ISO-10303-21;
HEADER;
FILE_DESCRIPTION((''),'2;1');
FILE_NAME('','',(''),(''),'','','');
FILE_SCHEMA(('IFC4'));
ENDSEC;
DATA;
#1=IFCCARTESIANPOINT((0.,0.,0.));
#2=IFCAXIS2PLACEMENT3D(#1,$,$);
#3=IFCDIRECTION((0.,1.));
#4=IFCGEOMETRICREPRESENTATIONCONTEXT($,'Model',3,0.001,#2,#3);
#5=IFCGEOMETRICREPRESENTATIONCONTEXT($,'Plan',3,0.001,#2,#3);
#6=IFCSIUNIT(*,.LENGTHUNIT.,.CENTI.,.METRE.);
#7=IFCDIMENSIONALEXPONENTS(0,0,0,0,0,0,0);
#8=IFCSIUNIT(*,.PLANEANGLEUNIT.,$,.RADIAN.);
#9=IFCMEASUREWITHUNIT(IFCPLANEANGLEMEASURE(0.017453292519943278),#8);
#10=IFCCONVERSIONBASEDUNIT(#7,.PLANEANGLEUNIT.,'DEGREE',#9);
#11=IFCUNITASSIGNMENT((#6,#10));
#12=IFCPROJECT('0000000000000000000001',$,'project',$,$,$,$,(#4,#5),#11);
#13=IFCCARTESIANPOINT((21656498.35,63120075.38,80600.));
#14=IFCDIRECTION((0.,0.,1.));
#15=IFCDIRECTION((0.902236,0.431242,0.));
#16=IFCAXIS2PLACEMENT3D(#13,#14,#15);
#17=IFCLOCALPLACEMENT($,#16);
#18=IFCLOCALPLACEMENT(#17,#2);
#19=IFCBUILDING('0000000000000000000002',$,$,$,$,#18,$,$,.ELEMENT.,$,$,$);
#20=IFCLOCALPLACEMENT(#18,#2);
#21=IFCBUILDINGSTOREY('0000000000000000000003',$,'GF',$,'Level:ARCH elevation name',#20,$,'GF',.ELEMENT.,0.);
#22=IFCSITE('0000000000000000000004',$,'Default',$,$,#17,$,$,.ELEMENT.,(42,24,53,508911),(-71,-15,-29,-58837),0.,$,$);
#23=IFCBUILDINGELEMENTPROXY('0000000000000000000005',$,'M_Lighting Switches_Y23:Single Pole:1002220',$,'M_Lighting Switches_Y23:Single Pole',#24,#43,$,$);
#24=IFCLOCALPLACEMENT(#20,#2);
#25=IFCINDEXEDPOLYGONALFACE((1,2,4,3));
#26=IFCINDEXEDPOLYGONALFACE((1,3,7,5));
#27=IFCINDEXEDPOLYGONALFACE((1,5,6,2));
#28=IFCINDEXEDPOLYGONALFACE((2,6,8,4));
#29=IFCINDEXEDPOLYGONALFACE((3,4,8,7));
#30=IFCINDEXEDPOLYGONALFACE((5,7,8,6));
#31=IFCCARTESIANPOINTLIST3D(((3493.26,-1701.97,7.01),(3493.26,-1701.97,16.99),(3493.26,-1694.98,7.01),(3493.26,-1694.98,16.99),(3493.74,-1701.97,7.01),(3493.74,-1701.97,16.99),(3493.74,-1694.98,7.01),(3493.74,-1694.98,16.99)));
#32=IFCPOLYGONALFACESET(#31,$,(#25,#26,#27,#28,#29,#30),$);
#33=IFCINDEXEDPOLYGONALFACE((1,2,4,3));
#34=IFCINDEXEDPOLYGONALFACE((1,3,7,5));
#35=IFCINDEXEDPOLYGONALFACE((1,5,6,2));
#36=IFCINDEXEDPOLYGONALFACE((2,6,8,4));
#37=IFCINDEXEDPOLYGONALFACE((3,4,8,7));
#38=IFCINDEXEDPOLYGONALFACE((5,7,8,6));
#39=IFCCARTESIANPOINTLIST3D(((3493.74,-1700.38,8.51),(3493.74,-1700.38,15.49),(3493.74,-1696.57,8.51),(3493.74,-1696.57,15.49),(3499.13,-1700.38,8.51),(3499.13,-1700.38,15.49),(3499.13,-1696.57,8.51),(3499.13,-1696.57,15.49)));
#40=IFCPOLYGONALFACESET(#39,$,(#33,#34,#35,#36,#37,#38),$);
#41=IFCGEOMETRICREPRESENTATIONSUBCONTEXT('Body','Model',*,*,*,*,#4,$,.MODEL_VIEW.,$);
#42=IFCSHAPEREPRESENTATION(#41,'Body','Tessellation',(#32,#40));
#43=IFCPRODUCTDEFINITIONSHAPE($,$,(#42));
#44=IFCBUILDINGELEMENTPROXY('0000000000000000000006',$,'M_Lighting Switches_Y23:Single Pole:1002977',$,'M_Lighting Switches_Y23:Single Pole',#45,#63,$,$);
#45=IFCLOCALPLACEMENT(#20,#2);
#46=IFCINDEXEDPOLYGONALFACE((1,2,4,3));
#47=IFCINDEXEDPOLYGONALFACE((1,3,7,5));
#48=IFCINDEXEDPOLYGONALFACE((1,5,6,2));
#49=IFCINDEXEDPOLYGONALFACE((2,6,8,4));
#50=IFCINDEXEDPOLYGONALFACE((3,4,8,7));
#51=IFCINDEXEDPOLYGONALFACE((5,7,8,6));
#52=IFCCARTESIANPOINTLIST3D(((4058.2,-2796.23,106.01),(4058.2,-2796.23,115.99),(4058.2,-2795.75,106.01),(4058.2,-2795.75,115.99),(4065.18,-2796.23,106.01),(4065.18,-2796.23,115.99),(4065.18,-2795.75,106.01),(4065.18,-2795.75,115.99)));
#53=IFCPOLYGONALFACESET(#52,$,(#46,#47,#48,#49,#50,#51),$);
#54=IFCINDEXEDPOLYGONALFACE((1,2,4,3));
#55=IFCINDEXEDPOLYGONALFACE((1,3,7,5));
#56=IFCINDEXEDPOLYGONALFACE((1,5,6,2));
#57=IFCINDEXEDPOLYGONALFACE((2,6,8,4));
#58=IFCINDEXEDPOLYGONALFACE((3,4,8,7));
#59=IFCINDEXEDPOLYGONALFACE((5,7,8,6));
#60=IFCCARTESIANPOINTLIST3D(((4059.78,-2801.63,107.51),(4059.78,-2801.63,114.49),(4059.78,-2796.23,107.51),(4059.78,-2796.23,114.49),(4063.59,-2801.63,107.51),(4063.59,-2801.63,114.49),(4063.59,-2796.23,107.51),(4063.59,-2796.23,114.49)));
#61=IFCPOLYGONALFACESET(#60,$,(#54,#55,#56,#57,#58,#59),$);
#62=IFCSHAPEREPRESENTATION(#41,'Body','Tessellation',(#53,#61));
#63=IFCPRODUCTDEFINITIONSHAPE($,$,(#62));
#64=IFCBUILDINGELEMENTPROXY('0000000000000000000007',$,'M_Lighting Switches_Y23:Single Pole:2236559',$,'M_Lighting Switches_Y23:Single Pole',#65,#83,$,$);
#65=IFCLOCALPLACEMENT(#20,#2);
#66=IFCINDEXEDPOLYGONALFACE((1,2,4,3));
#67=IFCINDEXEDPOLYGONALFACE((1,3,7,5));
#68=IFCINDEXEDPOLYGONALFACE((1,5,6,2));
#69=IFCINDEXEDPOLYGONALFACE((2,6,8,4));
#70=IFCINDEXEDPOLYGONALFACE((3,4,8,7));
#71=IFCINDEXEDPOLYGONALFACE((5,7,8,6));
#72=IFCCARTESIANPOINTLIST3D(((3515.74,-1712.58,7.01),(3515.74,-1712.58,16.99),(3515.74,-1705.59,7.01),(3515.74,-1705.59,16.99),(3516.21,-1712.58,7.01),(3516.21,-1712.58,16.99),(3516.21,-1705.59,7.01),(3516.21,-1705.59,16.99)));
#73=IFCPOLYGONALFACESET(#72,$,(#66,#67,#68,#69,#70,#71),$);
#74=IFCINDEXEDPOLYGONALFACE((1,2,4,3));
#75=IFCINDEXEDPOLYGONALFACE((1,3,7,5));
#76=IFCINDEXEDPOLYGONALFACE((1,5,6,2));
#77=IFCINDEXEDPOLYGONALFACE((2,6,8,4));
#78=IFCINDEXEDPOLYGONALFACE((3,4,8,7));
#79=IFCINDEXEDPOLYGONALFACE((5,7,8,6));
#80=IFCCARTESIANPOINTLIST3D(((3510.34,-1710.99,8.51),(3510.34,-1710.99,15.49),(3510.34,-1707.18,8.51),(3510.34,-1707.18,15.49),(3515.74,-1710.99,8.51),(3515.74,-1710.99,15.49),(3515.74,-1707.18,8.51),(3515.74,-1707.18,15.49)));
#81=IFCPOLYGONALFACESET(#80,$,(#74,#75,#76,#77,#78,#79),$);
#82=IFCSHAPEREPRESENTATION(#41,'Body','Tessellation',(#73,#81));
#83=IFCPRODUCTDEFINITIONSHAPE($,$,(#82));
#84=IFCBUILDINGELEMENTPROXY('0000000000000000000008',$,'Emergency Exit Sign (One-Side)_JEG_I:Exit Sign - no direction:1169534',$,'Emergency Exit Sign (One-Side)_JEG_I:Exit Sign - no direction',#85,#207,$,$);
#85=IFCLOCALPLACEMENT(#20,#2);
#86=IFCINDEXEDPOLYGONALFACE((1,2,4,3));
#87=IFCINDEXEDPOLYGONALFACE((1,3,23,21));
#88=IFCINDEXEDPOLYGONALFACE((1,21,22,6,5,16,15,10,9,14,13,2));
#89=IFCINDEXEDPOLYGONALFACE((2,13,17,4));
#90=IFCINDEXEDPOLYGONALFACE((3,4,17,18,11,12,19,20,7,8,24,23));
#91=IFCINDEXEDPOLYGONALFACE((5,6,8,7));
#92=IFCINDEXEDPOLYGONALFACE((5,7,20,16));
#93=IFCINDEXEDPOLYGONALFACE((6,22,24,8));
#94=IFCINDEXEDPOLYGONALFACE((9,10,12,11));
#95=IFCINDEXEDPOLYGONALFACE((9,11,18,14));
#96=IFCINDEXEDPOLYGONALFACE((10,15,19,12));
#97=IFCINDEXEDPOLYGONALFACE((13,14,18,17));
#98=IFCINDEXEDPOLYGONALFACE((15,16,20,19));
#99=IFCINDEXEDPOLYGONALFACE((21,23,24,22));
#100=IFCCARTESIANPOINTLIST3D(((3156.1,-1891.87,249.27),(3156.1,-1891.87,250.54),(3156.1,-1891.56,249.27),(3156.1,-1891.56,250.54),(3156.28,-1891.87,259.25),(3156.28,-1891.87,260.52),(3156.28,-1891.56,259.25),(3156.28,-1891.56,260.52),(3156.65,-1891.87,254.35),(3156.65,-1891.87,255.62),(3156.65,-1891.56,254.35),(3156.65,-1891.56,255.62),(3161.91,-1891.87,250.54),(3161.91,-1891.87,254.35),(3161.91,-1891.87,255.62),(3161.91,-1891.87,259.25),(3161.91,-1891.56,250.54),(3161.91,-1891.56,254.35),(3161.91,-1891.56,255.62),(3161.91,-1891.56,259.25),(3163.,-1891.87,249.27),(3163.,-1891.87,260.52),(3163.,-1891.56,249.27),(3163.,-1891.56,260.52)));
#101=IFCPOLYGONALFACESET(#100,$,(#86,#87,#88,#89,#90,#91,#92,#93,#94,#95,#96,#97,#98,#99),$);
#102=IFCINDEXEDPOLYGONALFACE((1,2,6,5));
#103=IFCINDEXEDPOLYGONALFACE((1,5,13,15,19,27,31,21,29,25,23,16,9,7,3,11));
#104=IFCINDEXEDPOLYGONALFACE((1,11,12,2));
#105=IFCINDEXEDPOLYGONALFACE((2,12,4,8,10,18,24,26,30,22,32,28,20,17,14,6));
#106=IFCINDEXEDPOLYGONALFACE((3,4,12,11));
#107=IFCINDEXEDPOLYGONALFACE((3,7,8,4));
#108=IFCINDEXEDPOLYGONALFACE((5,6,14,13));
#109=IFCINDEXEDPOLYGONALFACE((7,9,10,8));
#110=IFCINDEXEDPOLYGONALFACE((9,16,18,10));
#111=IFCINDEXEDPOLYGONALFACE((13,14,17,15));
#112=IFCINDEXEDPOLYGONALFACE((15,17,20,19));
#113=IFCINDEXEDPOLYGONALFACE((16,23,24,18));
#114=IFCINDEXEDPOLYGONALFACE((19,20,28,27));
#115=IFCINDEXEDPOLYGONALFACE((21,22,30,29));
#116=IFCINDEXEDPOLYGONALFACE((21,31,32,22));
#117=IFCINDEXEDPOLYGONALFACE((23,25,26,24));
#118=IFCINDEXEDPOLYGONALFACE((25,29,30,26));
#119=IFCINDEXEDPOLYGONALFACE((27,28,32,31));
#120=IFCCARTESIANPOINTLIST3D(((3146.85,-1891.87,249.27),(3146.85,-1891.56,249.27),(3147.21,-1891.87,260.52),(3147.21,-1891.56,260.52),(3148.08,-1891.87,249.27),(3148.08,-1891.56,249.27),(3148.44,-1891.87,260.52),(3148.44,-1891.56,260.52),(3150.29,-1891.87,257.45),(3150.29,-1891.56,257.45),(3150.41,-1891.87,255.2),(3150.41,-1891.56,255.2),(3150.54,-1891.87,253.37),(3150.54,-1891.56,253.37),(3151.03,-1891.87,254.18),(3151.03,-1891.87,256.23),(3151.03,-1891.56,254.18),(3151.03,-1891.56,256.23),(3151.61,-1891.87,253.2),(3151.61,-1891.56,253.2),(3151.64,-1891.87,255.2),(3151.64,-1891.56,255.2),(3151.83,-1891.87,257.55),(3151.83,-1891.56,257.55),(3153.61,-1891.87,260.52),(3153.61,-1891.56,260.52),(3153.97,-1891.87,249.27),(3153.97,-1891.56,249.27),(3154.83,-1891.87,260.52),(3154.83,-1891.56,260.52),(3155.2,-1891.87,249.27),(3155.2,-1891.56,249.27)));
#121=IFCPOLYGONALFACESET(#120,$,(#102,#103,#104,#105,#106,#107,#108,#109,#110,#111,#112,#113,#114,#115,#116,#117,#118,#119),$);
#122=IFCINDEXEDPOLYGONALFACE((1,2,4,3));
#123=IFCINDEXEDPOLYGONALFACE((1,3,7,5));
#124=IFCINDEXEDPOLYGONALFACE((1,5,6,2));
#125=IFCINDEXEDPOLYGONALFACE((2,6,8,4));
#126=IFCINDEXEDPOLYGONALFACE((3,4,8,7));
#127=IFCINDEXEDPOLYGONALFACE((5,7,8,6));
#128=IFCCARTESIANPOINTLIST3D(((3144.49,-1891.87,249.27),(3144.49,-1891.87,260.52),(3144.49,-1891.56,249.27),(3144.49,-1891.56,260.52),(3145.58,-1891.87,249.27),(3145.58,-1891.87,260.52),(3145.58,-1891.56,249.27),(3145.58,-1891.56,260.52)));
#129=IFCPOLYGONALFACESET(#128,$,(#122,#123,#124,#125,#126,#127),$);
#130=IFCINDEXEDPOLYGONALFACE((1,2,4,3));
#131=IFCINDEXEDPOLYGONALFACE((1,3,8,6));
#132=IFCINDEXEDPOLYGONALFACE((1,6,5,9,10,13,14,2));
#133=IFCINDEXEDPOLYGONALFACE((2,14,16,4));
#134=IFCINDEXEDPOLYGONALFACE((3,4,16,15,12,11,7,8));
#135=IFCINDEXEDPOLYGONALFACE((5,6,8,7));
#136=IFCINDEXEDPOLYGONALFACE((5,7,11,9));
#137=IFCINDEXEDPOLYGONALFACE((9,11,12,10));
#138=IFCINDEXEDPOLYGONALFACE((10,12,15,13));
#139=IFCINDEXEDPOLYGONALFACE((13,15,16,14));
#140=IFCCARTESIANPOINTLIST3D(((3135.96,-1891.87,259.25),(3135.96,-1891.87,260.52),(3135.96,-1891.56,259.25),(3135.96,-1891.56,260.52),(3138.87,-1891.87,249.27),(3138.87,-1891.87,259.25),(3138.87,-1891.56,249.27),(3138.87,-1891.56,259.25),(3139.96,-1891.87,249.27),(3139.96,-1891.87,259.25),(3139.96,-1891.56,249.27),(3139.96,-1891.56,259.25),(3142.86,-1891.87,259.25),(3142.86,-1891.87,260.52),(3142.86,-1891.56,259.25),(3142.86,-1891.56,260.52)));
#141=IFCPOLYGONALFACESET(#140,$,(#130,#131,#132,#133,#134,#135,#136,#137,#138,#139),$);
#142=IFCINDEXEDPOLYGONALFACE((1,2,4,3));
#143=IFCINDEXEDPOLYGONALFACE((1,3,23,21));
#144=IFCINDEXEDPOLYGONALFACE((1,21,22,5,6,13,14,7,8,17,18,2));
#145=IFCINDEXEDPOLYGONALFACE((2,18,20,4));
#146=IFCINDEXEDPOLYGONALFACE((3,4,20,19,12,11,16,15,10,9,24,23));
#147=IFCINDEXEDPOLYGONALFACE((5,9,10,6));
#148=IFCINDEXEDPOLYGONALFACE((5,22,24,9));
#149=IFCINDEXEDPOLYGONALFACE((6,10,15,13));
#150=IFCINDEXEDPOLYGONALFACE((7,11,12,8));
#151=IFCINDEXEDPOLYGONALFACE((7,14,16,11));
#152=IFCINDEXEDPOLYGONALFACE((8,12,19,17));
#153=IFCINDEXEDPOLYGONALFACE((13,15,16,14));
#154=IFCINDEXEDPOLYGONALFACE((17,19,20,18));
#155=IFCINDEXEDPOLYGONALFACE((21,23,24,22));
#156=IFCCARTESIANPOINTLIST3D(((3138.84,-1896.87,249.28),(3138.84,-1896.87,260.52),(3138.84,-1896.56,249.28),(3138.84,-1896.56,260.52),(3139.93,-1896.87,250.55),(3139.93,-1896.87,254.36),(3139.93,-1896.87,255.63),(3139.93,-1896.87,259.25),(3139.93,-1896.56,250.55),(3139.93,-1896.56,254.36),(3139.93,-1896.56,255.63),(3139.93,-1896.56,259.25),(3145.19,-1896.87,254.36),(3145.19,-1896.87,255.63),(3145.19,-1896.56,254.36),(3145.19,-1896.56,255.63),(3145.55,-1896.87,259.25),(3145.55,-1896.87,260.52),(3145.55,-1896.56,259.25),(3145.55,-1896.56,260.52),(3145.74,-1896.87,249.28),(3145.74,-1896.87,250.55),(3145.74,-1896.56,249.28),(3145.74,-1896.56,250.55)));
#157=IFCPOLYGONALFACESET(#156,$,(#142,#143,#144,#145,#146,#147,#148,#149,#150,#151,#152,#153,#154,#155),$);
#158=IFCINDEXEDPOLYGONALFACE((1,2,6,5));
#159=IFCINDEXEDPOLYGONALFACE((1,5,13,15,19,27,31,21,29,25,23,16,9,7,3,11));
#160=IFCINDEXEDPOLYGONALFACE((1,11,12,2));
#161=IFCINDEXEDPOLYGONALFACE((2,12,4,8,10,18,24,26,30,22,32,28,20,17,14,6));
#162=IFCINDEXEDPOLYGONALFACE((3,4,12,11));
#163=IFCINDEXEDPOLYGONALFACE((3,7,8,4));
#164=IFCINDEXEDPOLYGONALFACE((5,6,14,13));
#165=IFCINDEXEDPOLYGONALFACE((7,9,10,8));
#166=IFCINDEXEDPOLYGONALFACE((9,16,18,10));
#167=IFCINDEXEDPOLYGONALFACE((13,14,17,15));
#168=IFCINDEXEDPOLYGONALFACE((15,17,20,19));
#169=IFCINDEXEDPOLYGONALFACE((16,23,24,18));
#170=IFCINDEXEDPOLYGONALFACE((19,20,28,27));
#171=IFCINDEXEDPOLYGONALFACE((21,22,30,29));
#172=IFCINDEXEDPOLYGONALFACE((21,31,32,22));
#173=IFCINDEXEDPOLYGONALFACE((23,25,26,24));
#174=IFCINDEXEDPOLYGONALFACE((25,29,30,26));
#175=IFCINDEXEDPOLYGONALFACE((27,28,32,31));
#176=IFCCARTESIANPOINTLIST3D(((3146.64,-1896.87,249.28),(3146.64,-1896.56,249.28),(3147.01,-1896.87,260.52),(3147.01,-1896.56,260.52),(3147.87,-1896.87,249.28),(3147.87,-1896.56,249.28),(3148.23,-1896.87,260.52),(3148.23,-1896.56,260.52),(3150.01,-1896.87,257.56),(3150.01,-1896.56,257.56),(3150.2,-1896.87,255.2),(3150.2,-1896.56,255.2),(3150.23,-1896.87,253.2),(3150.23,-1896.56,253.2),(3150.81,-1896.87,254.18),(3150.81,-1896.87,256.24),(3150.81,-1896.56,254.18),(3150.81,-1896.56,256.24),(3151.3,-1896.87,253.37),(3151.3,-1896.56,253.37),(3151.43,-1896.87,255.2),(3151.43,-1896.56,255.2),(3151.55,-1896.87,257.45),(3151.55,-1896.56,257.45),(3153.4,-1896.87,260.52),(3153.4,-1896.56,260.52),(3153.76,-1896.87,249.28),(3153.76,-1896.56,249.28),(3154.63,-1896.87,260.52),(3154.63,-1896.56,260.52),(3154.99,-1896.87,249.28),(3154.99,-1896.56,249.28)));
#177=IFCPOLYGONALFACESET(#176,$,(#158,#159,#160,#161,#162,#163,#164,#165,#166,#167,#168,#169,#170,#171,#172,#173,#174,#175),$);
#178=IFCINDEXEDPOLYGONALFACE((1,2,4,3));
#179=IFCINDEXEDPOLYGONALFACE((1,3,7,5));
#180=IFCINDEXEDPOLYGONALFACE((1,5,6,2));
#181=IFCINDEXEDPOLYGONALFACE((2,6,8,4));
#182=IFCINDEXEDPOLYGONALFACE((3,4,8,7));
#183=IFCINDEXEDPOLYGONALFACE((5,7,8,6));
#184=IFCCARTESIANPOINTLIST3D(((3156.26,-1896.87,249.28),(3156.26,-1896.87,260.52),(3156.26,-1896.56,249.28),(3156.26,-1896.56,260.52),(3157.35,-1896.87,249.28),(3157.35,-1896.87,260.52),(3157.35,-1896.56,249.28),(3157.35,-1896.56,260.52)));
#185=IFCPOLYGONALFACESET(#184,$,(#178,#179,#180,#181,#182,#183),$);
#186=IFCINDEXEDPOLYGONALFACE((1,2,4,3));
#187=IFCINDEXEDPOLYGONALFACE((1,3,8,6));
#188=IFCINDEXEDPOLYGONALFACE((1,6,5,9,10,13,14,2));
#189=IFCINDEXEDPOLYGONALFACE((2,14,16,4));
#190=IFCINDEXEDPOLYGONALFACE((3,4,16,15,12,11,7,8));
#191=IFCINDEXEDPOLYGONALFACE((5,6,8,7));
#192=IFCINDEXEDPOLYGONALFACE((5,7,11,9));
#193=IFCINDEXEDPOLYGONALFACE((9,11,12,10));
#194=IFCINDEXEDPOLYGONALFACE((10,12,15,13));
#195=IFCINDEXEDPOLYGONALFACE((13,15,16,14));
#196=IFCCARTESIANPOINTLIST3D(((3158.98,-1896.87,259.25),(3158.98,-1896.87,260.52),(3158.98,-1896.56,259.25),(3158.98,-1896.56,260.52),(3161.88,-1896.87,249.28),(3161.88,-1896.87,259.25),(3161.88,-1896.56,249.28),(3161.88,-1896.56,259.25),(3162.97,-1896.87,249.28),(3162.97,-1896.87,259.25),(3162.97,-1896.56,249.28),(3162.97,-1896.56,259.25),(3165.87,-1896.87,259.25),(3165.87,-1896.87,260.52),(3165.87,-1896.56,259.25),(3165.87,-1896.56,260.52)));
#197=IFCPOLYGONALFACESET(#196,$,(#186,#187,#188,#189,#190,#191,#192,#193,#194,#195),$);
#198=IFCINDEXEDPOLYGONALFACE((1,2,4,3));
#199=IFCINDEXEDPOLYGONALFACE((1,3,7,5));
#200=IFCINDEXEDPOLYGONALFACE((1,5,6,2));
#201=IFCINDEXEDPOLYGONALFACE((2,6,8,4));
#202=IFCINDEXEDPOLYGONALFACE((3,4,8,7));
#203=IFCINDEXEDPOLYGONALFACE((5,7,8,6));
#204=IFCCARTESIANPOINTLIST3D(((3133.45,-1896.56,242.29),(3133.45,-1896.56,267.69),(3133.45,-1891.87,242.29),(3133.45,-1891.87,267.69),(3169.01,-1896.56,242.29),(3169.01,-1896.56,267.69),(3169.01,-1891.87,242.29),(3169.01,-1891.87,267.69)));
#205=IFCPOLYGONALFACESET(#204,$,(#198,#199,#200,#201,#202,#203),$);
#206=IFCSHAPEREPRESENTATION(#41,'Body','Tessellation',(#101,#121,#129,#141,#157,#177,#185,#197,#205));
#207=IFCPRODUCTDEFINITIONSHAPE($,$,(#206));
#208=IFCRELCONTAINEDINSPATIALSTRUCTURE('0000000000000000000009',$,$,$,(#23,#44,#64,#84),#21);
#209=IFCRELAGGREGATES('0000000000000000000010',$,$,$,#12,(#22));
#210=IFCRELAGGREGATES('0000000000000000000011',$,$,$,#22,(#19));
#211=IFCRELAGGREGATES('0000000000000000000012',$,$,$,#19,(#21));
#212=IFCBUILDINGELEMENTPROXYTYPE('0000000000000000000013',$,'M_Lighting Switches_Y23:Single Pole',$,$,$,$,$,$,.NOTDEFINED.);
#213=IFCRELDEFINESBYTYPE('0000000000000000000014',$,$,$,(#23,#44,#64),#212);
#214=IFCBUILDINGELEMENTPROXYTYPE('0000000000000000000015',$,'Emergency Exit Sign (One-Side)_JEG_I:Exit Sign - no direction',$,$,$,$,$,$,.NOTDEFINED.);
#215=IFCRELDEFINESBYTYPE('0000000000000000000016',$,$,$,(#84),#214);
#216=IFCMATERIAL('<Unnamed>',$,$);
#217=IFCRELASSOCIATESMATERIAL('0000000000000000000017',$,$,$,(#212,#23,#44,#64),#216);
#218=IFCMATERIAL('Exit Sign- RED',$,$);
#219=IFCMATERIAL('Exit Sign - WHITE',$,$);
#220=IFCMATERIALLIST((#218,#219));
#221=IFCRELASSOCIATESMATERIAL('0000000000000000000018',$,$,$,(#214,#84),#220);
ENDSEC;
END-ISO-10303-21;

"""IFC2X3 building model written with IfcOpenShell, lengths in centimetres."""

from ifc_helpers import new_model, entity, si_unit, converted_unit, direction, frame, frame_2d, origin, origin_2d_with_axis, place, context, subcontext, project, spatial, polyline, rectangle, outline, extrude, source, transform, mapped, material, material_list, type_object, type_shapes, element, save


model = new_model("IFC2X3")

# Units and contexts
model_context = context("Model", 3, precision=0.001, world=origin(), true_north=direction((0.0, 1.0)))
plan_context = context("Plan", 3, precision=0.001, world=origin(), true_north=direction((0.0, 1.0)))
body_context = subcontext(model_context, "Body", "Model", "MODEL_VIEW")
ifc_project = project(units=[si_unit("LENGTHUNIT", "METRE", prefix="CENTI"), converted_unit("PLANEANGLEUNIT", "DEGREE", entity("IfcPlaneAngleMeasure", 0.017453292519943278), si_unit("PLANEANGLEUNIT", "RADIAN"), dimensions=[0, 0, 0, 0, 0, 0, 0])], contexts=[model_context, plan_context])

# Site, building, storey
site_placement = place(None, frame((21656498.35, 63120075.38, 80600.0), z_axis=(0.0, 0.0, 1.0), x_axis=(0.902236, 0.431242, 0.0)))
site = spatial("IfcSite", under=ifc_project, at=site_placement, Name="Default", CompositionType="ELEMENT", RefLatitude=(42, 24, 53, 508911), RefLongitude=(-71, -15, -29, -58837), RefElevation=0.0)
building_placement = place(site_placement, origin())
building = spatial("IfcBuilding", under=site, at=building_placement, CompositionType="ELEMENT")
storey_placement = place(building_placement, origin())
storey = spatial("IfcBuildingStorey", under=building, at=storey_placement, Name="GF", ObjectType="Level:ARCH elevation name", LongName="GF", CompositionType="ELEMENT", Elevation=0.0)

# Building element proxies
ifc_material_1 = material(Name="<Unnamed>")
building_element_proxy_type_1 = type_object("IfcBuildingElementProxyType", Name="M_Lighting Switches_Y23:Single Pole", PredefinedType="NOTDEFINED", material=ifc_material_1)
shared_shape_1 = source(origin(), body_context, "Body", "SweptSolid", [
    extrude(rectangle(XDim=6.99, YDim=9.98, at=frame_2d((0.0, 0.0), x_axis=(1.0, 0.0))), frame((0.0, 0.0, 0.0), z_axis=(0.0, 0.0, 1.0), x_axis=(-1.0, 0.0, 0.0)), (0.0, 0.0, 1.0), 0.48),
    extrude(rectangle(XDim=3.81, YDim=6.98, at=frame_2d((0.0, 0.0), x_axis=(1.0, 0.0))), frame((0.0, 0.0, -5.4), z_axis=(0.0, 0.0, 1.0), x_axis=(-1.0, 0.0, 0.0)), (0.0, 0.0, 1.0), 5.4),
])
type_shapes(building_element_proxy_type_1, [shared_shape_1])
for number, where, z_axis, x_axis, name in (
    (1, (3493.74, -1698.47, 12.0), (-1.0, 0.0, 0.0), (0.0, 1.0, 0.0), "M_Lighting Switches_Y23:Single Pole:1002220"),
    (2, (4061.69, -2796.23, 111.0), (0.0, 1.0, 0.0), (1.0, 0.0, 0.0), "M_Lighting Switches_Y23:Single Pole:1002977"),
    (3, (3515.74, -1709.09, 12.0), (1.0, 0.0, 0.0), (0.0, -1.0, 0.0), "M_Lighting Switches_Y23:Single Pole:2236559"),
):
    element("IfcBuildingElementProxy", number, at=place(storey_placement, frame(where, z_axis=z_axis, x_axis=x_axis)), inside=storey, type_object=building_element_proxy_type_1, material=ifc_material_1, Name=name, ObjectType="M_Lighting Switches_Y23:Single Pole", context=body_context, shape_type="MappedRepresentation", body=[
        mapped(shared_shape_1, transform((0.0, 0.0, 0.0), scale=1.0)),
    ])
ifc_material_2 = material(Name="Exit Sign- RED")
ifc_material_3 = material(Name="Exit Sign - WHITE")
ifc_material_list_1 = material_list([ifc_material_2, ifc_material_3])
building_element_proxy_type_2 = type_object("IfcBuildingElementProxyType", Name="Emergency Exit Sign (One-Side)_JEG_I:Exit Sign - no direction", PredefinedType="NOTDEFINED", material=ifc_material_list_1)
shared_shape_2 = source(origin(), body_context, "Body", "SweptSolid", [
    extrude(outline(polyline([(-5.65, -3.69), (5.59, -3.69), (5.59, 3.02), (4.32, 3.02), (4.32, -2.6), (0.7, -2.6), (0.7, 2.66), (-0.57, 2.66), (-0.57, -2.6), (-4.38, -2.6), (-4.38, 3.21), (-5.65, 3.21), (-5.65, -3.69)])), frame((-8.08, -5.22, 12.64), z_axis=(0.0, 1.0, 0.0), x_axis=(0.0, 0.0, 1.0)), (0.0, 0.0, 1.0), 0.32),
    extrude(outline(polyline([(-7.14, 0.57), (-6.5, -0.49), (-1.93, -0.48), (-0.78, -0.48), (-1.23, -1.32), (-3.47, -5.53), (-2.84, -6.59), (0.41, -0.48), (6.62, -0.48), (5.99, 0.57), (2.4, 0.57), (0.98, 0.58), (1.7, 1.94), (3.32, 5.0), (2.69, 6.05), (-0.22, 0.57), (-7.14, 0.57)])), frame((0.2, -5.22, 12.81), z_axis=(0.0, -1.0, 0.0), x_axis=(0.515099, 0.0, 0.857131)), (0.0, 0.0, -1.0), 0.32),
    extrude(rectangle(XDim=0.32, YDim=1.09, at=frame_2d((0.0, 0.0), x_axis=(1.0, 0.0))), frame((6.19, -5.06, 6.99), z_axis=(0.0, 0.0, 1.0), x_axis=(0.0, 1.0, 0.0)), (0.0, 0.0, 1.0), 11.25),
    extrude(outline(polyline([(-7.8, 0.54), (-7.8, -0.54), (2.18, -0.54), (2.18, -3.45), (3.45, -3.45), (3.45, 3.45), (2.18, 3.45), (2.18, 0.54), (-7.8, 0.54)])), frame((11.82, -5.22, 14.79), z_axis=(0.0, -1.0, 0.0), x_axis=(0.0, 0.0, 1.0)), (0.0, 0.0, -1.0), 0.32),
    extrude(outline(polyline([(-3.69, -5.65), (3.21, -5.65), (3.21, -4.38), (-2.6, -4.38), (-2.6, -0.57), (2.66, -0.57), (2.66, 0.7), (-2.6, 0.7), (-2.6, 4.32), (3.02, 4.32), (3.02, 5.59), (-3.69, 5.59), (-3.69, -5.65)])), frame((8.7, -0.22, 12.65), z_axis=(0.0, 1.0, 0.0), x_axis=(-1.0, 0.0, 0.0)), (0.0, 0.0, 1.0), 0.32),
    extrude(outline(polyline([(-4.16, -5.82), (-2.93, -5.82), (-0.58, -1.9), (0.01, -0.92), (0.5, -1.73), (2.96, -5.82), (4.18, -5.82), (0.62, 0.1), (3.82, 5.42), (2.59, 5.42), (0.75, 2.35), (0.01, 1.14), (-0.79, 2.46), (-2.57, 5.42), (-3.8, 5.42), (-0.6, 0.1), (-4.16, -5.82)])), frame((0.43, -0.22, 12.82), z_axis=(0.0, 1.0, 0.0), x_axis=(-1.0, 0.0, 0.0)), (0.0, 0.0, 1.0), 0.32),
    extrude(rectangle(XDim=0.32, YDim=1.09, at=origin_2d_with_axis()), frame((-5.57, -0.06, 6.99), z_axis=(0.0, 0.0, 1.0), x_axis=(0.0, -1.0, 0.0)), (0.0, 0.0, 1.0), 11.25),
    extrude(outline(polyline([(-0.54, -7.8), (0.54, -7.8), (0.54, 2.18), (3.45, 2.18), (3.45, 3.45), (-3.45, 3.45), (-3.45, 2.18), (-0.54, 2.18), (-0.54, -7.8)])), frame((-11.2, -0.22, 14.79), z_axis=(0.0, 1.0, 0.0), x_axis=(-1.0, 0.0, 0.0)), (0.0, 0.0, 1.0), 0.32),
    extrude(rectangle(XDim=4.68, YDim=35.56, at=origin_2d_with_axis()), frame((0.0, -2.56, 0.01), z_axis=(0.0, 0.0, 1.0), x_axis=(0.0, 1.0, 0.0)), (0.0, 0.0, 1.0), 25.4),
])
type_shapes(building_element_proxy_type_2, [shared_shape_2])
for number, where, z_axis, x_axis, name in (
    (4, (3151.23, -1896.78, 242.28), (0.0, 0.0, 1.0), (-1.0, 0.0, 0.0), "Emergency Exit Sign (One-Side)_JEG_I:Exit Sign - no direction:1169534"),
):
    element("IfcBuildingElementProxy", number, at=place(storey_placement, frame(where, z_axis=z_axis, x_axis=x_axis)), inside=storey, type_object=building_element_proxy_type_2, material=ifc_material_list_1, Name=name, ObjectType="Emergency Exit Sign (One-Side)_JEG_I:Exit Sign - no direction", context=body_context, shape_type="MappedRepresentation", body=[
        mapped(shared_shape_2, transform((0.0, 0.0, 0.0), scale=1.0)),
    ])

save(model, "model.ifc")
